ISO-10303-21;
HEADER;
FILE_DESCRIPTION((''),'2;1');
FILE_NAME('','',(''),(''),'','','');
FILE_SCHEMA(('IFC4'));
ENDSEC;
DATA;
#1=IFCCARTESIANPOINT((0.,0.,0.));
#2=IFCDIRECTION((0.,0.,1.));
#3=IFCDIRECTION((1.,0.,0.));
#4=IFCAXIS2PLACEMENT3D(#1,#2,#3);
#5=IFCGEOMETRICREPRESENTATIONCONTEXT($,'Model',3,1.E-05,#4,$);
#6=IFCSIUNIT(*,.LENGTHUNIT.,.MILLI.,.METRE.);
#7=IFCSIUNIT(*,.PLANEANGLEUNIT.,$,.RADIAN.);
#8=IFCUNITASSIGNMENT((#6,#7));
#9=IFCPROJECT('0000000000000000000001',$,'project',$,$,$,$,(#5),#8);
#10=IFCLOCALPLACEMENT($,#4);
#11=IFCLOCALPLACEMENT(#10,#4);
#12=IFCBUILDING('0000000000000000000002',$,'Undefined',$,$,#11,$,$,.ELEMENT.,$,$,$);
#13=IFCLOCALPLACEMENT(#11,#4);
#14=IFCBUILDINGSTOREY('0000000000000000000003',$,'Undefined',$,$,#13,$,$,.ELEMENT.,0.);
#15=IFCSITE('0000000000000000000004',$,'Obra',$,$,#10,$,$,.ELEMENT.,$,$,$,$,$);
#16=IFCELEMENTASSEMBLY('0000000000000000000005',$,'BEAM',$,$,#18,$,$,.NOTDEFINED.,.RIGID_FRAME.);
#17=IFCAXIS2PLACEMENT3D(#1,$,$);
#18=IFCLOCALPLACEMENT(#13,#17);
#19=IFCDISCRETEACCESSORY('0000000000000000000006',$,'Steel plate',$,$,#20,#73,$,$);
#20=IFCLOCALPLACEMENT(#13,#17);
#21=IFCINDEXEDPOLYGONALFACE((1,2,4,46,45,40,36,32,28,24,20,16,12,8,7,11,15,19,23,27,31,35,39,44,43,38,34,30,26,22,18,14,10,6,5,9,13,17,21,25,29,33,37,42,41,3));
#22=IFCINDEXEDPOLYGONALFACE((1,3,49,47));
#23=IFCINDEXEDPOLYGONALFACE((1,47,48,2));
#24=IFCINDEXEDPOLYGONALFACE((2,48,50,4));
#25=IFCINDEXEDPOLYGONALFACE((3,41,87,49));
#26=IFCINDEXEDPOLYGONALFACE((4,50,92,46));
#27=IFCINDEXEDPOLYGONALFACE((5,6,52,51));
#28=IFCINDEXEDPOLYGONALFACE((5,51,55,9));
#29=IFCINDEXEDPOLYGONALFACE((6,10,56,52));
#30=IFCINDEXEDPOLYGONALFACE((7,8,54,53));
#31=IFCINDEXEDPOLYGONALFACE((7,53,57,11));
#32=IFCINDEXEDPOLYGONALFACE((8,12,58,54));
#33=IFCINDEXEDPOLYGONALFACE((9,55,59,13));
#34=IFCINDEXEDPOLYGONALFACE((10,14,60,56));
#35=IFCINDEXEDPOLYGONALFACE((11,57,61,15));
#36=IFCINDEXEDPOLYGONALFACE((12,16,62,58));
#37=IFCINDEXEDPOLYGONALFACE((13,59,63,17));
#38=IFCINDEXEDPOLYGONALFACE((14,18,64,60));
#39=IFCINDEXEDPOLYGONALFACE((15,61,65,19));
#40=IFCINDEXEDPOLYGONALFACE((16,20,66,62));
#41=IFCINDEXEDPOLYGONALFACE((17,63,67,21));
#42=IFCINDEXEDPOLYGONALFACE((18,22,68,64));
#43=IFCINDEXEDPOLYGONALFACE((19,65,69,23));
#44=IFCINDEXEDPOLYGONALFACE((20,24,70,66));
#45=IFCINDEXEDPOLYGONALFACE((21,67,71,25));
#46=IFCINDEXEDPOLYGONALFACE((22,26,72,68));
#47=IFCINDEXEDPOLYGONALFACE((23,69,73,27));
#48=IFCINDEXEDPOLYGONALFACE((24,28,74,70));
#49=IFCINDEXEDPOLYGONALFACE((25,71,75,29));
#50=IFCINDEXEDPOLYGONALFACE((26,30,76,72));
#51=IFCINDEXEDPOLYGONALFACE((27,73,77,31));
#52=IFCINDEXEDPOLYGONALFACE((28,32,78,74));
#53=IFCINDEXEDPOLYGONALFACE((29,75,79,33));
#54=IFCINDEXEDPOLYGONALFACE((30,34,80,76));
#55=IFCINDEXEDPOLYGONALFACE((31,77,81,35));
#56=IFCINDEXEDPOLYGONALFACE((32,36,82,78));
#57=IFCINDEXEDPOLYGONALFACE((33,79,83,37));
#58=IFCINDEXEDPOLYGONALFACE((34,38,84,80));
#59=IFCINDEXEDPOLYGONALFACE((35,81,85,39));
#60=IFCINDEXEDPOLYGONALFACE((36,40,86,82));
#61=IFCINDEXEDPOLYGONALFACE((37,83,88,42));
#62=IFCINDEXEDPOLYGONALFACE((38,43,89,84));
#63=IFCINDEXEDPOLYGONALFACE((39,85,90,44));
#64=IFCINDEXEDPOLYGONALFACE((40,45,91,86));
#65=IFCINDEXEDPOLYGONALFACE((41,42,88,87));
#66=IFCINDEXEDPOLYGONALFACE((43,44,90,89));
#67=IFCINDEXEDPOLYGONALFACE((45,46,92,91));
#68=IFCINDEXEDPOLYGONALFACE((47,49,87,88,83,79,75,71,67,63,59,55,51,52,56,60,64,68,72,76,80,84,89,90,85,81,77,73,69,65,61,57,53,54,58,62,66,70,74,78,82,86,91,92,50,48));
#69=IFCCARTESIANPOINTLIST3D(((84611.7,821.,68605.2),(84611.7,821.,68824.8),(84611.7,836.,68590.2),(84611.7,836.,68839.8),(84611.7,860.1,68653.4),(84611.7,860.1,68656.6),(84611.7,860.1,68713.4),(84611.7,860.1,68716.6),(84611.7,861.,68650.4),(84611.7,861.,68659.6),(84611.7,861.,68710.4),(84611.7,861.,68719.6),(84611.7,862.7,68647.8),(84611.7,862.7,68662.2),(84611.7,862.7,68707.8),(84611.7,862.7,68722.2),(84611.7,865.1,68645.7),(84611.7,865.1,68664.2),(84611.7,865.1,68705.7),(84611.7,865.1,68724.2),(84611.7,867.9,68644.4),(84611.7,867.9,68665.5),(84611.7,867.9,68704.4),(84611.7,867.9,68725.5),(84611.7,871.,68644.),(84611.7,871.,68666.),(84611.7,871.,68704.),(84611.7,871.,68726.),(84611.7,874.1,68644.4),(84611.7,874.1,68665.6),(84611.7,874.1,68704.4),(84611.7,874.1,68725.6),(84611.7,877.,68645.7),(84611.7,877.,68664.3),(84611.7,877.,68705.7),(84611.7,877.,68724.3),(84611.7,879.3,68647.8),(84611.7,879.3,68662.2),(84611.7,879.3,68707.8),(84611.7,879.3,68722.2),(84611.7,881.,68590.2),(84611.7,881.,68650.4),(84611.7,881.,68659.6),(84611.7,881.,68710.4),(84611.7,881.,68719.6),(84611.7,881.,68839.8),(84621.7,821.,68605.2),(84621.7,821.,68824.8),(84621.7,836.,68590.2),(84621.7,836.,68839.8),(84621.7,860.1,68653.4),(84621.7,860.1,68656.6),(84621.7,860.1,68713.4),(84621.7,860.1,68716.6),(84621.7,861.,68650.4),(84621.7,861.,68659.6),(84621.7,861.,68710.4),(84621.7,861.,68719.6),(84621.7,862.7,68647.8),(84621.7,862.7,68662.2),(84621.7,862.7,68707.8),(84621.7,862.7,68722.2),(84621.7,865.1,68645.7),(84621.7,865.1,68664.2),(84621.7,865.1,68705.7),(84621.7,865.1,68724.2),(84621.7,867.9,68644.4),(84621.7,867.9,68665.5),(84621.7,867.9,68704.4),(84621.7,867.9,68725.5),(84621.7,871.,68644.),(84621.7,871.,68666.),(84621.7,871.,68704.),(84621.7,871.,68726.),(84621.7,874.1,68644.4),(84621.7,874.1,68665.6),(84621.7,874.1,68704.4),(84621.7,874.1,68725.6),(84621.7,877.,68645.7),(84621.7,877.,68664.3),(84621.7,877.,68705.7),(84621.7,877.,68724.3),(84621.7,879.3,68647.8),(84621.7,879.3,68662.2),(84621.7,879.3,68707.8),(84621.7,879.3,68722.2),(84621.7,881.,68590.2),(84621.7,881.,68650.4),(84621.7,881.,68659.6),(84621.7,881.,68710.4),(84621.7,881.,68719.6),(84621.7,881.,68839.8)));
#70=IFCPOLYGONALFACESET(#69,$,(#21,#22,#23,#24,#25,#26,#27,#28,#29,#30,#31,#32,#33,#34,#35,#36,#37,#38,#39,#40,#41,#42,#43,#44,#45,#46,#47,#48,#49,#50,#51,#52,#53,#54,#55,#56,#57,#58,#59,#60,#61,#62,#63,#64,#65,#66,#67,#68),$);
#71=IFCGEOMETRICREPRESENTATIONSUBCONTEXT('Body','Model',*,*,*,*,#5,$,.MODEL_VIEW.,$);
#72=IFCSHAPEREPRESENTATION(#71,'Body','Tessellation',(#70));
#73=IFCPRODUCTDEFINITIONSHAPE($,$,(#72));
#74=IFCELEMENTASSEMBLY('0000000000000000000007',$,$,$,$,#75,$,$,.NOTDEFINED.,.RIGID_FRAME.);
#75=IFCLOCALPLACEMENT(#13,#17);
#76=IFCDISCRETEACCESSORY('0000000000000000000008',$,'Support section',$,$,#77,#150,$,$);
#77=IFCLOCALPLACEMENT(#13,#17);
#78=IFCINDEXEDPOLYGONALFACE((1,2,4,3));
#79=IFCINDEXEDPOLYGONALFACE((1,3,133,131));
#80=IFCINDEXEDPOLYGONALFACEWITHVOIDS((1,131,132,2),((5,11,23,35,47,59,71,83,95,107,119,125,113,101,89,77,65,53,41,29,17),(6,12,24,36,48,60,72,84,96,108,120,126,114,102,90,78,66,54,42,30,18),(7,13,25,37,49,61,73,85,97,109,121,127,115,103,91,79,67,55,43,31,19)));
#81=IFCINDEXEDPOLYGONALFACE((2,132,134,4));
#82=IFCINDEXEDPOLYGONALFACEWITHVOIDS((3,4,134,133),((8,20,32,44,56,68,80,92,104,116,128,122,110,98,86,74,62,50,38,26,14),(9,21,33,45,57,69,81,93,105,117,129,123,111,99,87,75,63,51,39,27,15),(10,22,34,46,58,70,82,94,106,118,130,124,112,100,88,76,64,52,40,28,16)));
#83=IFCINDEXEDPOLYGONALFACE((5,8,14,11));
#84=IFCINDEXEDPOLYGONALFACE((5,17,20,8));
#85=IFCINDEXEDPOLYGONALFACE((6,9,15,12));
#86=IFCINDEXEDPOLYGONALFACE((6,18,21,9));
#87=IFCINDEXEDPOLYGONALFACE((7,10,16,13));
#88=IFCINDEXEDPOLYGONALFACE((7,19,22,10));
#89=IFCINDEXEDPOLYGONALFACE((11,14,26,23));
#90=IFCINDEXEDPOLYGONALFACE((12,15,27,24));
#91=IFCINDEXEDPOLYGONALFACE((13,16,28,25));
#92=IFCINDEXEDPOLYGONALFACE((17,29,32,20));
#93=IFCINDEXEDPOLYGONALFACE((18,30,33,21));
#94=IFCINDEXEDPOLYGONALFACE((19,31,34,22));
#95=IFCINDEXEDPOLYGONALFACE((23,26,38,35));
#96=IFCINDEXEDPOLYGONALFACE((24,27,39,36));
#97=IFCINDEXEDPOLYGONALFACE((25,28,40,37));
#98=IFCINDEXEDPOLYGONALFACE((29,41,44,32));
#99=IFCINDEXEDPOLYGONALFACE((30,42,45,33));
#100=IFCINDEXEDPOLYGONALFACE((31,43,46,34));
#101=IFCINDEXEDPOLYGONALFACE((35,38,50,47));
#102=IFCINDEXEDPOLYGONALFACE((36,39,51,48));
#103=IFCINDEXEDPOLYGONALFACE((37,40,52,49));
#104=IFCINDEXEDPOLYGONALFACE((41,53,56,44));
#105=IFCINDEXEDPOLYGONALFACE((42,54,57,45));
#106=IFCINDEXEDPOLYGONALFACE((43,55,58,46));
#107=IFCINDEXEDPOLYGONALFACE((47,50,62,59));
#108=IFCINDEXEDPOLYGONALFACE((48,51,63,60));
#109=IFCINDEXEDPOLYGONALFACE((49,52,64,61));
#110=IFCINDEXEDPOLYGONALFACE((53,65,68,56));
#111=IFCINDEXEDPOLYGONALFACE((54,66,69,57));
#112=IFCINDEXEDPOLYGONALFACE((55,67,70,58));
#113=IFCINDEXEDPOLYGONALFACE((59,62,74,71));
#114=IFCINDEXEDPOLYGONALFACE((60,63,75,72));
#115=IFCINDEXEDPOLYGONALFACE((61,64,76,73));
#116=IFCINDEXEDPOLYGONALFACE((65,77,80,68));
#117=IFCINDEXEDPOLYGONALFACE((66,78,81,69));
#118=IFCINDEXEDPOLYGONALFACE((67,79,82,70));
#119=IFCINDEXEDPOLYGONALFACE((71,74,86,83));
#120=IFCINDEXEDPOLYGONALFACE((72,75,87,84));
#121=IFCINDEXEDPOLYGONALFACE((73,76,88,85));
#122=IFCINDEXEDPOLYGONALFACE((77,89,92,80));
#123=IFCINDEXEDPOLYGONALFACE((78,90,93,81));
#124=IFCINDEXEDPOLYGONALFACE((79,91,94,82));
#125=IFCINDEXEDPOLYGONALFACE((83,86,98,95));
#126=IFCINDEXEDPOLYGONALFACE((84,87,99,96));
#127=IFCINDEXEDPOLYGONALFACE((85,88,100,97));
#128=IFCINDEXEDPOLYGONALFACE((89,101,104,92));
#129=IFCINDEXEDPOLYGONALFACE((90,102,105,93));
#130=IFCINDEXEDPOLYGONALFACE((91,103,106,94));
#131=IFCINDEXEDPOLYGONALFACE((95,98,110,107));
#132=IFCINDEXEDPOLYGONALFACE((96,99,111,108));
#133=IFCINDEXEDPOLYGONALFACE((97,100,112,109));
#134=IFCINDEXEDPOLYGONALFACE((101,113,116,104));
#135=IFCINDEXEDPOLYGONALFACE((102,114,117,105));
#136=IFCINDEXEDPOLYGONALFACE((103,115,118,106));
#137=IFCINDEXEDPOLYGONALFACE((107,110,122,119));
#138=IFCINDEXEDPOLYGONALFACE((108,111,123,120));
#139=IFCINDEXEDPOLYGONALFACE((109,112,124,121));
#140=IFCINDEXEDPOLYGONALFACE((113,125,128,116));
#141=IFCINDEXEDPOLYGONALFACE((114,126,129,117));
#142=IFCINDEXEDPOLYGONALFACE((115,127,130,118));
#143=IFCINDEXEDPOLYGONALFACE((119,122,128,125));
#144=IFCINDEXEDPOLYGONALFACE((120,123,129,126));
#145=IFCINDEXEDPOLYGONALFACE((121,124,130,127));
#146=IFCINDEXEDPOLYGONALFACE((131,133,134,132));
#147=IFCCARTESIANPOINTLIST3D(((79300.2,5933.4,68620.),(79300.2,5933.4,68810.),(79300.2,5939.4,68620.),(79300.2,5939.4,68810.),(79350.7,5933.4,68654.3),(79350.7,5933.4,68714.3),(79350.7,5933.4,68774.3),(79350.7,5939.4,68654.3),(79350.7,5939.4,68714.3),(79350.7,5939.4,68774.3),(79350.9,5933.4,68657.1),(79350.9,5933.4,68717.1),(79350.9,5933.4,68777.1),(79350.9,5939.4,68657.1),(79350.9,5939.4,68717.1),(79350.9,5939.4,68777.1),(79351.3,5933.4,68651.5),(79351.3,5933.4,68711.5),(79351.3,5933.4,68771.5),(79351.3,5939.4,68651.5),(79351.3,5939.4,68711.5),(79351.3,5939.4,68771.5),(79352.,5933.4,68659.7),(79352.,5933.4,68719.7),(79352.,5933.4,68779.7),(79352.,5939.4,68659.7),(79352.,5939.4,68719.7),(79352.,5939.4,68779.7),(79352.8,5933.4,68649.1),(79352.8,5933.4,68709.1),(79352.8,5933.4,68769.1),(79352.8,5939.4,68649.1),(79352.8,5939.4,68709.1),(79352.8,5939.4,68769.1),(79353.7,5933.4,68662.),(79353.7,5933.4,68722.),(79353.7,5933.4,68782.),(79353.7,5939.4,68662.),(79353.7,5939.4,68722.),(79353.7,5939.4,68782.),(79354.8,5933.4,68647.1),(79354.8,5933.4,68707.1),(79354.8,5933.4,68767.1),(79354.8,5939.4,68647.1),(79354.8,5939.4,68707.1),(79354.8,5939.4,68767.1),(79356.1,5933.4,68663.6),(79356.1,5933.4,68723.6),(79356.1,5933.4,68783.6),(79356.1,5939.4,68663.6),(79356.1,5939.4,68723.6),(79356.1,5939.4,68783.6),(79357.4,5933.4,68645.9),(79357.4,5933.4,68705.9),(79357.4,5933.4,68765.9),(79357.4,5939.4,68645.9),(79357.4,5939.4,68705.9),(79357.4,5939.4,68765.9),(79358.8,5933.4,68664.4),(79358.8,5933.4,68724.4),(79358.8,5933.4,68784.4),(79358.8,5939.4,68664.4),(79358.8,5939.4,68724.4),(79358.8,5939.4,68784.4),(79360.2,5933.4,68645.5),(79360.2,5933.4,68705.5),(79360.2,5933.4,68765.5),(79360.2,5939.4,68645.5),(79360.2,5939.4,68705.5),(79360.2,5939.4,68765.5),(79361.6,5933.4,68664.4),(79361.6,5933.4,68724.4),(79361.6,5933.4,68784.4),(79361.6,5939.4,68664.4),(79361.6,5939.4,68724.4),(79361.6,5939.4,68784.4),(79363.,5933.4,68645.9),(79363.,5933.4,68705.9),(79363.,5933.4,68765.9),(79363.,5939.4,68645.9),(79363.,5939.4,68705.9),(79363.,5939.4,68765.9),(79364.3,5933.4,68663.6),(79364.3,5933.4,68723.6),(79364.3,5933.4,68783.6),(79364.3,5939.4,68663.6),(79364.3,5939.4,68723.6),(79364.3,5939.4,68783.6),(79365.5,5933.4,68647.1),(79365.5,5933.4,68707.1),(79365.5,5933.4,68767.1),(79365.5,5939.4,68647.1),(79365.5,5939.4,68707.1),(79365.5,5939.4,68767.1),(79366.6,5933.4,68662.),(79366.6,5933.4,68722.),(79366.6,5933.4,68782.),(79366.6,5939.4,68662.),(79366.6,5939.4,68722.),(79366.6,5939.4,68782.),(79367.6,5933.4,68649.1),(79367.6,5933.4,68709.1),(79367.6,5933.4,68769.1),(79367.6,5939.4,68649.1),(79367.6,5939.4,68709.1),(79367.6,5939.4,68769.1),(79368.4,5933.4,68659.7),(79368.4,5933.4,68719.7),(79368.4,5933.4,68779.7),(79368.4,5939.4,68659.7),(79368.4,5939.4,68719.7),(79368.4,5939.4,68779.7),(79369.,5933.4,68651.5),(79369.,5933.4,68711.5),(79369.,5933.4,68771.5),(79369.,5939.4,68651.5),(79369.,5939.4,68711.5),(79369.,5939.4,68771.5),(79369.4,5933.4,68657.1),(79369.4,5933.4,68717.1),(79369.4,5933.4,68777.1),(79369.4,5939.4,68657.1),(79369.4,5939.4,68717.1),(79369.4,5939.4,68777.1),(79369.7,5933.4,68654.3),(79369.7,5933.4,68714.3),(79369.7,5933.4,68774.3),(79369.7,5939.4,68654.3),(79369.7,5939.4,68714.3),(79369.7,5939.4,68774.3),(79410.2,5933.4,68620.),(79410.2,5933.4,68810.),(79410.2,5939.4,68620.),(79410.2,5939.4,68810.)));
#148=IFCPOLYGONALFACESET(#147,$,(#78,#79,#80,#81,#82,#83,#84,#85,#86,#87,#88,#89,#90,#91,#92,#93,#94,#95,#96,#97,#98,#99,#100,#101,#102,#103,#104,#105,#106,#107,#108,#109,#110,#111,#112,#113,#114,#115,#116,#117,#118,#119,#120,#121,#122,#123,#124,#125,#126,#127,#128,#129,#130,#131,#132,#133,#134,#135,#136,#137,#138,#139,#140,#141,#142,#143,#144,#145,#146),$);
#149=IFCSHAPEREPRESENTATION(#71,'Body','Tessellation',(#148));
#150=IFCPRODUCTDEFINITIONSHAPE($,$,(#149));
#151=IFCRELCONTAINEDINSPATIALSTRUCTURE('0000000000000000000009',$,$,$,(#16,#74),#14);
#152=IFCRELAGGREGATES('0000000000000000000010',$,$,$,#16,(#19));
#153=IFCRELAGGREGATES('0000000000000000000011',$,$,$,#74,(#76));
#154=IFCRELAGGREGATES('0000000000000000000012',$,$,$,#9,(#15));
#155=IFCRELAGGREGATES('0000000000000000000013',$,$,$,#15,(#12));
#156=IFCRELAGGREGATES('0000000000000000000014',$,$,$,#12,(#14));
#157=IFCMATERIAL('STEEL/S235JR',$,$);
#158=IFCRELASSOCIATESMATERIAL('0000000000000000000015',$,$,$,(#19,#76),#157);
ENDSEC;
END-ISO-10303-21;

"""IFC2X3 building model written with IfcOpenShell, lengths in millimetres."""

from ifc_helpers import new_model, si_unit, frame, origin_with_axes, origin_2d_with_axis, place, context, subcontext, project, spatial, polyline, rectangle, circle, outline, extrude, source, transform, mapped, material, element, aggregate, save


model = new_model("IFC2X3")

# Units and contexts
model_context = context("Model", 3, precision=1e-05, world=origin_with_axes())
body_context = subcontext(model_context, "Body", "Model", "MODEL_VIEW")
ifc_project = project(units=[si_unit("LENGTHUNIT", "METRE", prefix="MILLI"), si_unit("PLANEANGLEUNIT", "RADIAN")], contexts=[model_context])

# Site, building, storey
site_placement = place(None, origin_with_axes())
site = spatial("IfcSite", under=ifc_project, at=site_placement, Name="Obra", CompositionType="ELEMENT")
building_placement = place(site_placement, origin_with_axes())
building = spatial("IfcBuilding", under=site, at=building_placement, Name="Undefined", CompositionType="ELEMENT")
storey_placement = place(building_placement, origin_with_axes())
storey = spatial("IfcBuildingStorey", under=building, at=storey_placement, Name="Undefined", CompositionType="ELEMENT", Elevation=0.0)

# Shared definitions
ifc_material = material(Name="STEEL/S235JR")

# Element assembly
assembly_1_placement = place(storey_placement, origin_with_axes())
assembly_1 = element("IfcElementAssembly", 1, at=assembly_1_placement, inside=storey, Name="BEAM", AssemblyPlace="NOTDEFINED", PredefinedType="RIGID_FRAME")

# Discrete accessory, opening
shared_shape_1 = source(origin_with_axes(), body_context, "Body", "SweptSolid", [
    extrude(circle(Radius=11.0, at=origin_2d_with_axis()), frame((0.0, -13.9, 0.0), z_axis=(0.0, 1.0, 0.0), x_axis=(1.0, 0.0, 0.0)), (0.0, 0.0, 1.0), 10.2),
])
discrete_accessory_1_placement = place(assembly_1_placement, frame((84616.7, 881.0, 68590.2), z_axis=(-1.0, 0.0, 0.0), x_axis=(0.0, -1.0, 0.0)))
discrete_accessory_1 = element("IfcDiscreteAccessory", 2, at=discrete_accessory_1_placement, material=ifc_material, Name="Steel plate", context=body_context, shape_type="SweptSolid", body=[
    extrude(outline(polyline([(0.0, 0.0), (45.0, 0.0), (60.0, 15.0), (60.0, 234.6), (45.0, 249.6), (0.0, 249.6), (0.0, 0.0)])), frame((0.0, 0.0, -5.0), z_axis=(0.0, 0.0, 1.0), x_axis=(1.0, 0.0, 0.0)), (0.0, 0.0, 1.0), 10.0),
])
opening_1_placement = place(assembly_1_placement, frame((84607.9, 831.0, 68850.0), z_axis=(0.0, 1.0, 0.0), x_axis=(0.0, 0.0, -1.0)))
element("IfcOpeningElement", 3, at=opening_1_placement, cuts=discrete_accessory_1, ObjectType="Opening", context=body_context, shape_type="MappedRepresentation", body=[
    mapped(shared_shape_1, transform((135.0, 0.0, 40.0))),
    mapped(shared_shape_1, transform((195.0, 0.0, 40.0))),
])
aggregate(assembly_1, [discrete_accessory_1])

# Element assembly, discrete accessory, opening
assembly_2_placement = place(storey_placement, origin_with_axes())
assembly_2 = element("IfcElementAssembly", 4, at=assembly_2_placement, inside=storey, AssemblyPlace="NOTDEFINED", PredefinedType="RIGID_FRAME")
discrete_accessory_2_placement = place(assembly_2_placement, frame((79355.2, 5936.4, 68620.0), z_axis=(0.0, 0.0, 1.0), x_axis=(-1.0, 0.0, 0.0)))
discrete_accessory_2 = element("IfcDiscreteAccessory", 5, at=discrete_accessory_2_placement, material=ifc_material, Name="Support section", context=body_context, shape_type="SweptSolid", body=[
    extrude(rectangle(XDim=6.0, YDim=110.0, at=origin_2d_with_axis()), frame((0.0, 0.0, 190.0), z_axis=(0.0, 0.0, -1.0), x_axis=(0.0, 1.0, 0.0)), (0.0, 0.0, 1.0), 190.0),
])
shared_shape_2 = source(origin_with_axes(), body_context, "Body", "SweptSolid", [
    extrude(circle(Radius=9.5, at=origin_2d_with_axis()), frame((0.0, -9.2, 0.0), z_axis=(0.0, 1.0, 0.0), x_axis=(1.0, 0.0, 0.0)), (0.0, 0.0, 1.0), 6.2),
])
opening_2_placement = place(assembly_2_placement, frame((79310.2, 5942.5, 68835.0), z_axis=(1.0, 0.0, 0.0), x_axis=(0.0, 0.0, -1.0)))
element("IfcOpeningElement", 6, at=opening_2_placement, cuts=discrete_accessory_2, ObjectType="Opening", context=body_context, shape_type="MappedRepresentation", body=[
    mapped(shared_shape_2, transform((60.0, 0.0, 50.0))),
    mapped(shared_shape_2, transform((120.0, 0.0, 50.0))),
    mapped(shared_shape_2, transform((180.0, 0.0, 50.0))),
])
aggregate(assembly_2, [discrete_accessory_2])

save(model, "model.ifc")
